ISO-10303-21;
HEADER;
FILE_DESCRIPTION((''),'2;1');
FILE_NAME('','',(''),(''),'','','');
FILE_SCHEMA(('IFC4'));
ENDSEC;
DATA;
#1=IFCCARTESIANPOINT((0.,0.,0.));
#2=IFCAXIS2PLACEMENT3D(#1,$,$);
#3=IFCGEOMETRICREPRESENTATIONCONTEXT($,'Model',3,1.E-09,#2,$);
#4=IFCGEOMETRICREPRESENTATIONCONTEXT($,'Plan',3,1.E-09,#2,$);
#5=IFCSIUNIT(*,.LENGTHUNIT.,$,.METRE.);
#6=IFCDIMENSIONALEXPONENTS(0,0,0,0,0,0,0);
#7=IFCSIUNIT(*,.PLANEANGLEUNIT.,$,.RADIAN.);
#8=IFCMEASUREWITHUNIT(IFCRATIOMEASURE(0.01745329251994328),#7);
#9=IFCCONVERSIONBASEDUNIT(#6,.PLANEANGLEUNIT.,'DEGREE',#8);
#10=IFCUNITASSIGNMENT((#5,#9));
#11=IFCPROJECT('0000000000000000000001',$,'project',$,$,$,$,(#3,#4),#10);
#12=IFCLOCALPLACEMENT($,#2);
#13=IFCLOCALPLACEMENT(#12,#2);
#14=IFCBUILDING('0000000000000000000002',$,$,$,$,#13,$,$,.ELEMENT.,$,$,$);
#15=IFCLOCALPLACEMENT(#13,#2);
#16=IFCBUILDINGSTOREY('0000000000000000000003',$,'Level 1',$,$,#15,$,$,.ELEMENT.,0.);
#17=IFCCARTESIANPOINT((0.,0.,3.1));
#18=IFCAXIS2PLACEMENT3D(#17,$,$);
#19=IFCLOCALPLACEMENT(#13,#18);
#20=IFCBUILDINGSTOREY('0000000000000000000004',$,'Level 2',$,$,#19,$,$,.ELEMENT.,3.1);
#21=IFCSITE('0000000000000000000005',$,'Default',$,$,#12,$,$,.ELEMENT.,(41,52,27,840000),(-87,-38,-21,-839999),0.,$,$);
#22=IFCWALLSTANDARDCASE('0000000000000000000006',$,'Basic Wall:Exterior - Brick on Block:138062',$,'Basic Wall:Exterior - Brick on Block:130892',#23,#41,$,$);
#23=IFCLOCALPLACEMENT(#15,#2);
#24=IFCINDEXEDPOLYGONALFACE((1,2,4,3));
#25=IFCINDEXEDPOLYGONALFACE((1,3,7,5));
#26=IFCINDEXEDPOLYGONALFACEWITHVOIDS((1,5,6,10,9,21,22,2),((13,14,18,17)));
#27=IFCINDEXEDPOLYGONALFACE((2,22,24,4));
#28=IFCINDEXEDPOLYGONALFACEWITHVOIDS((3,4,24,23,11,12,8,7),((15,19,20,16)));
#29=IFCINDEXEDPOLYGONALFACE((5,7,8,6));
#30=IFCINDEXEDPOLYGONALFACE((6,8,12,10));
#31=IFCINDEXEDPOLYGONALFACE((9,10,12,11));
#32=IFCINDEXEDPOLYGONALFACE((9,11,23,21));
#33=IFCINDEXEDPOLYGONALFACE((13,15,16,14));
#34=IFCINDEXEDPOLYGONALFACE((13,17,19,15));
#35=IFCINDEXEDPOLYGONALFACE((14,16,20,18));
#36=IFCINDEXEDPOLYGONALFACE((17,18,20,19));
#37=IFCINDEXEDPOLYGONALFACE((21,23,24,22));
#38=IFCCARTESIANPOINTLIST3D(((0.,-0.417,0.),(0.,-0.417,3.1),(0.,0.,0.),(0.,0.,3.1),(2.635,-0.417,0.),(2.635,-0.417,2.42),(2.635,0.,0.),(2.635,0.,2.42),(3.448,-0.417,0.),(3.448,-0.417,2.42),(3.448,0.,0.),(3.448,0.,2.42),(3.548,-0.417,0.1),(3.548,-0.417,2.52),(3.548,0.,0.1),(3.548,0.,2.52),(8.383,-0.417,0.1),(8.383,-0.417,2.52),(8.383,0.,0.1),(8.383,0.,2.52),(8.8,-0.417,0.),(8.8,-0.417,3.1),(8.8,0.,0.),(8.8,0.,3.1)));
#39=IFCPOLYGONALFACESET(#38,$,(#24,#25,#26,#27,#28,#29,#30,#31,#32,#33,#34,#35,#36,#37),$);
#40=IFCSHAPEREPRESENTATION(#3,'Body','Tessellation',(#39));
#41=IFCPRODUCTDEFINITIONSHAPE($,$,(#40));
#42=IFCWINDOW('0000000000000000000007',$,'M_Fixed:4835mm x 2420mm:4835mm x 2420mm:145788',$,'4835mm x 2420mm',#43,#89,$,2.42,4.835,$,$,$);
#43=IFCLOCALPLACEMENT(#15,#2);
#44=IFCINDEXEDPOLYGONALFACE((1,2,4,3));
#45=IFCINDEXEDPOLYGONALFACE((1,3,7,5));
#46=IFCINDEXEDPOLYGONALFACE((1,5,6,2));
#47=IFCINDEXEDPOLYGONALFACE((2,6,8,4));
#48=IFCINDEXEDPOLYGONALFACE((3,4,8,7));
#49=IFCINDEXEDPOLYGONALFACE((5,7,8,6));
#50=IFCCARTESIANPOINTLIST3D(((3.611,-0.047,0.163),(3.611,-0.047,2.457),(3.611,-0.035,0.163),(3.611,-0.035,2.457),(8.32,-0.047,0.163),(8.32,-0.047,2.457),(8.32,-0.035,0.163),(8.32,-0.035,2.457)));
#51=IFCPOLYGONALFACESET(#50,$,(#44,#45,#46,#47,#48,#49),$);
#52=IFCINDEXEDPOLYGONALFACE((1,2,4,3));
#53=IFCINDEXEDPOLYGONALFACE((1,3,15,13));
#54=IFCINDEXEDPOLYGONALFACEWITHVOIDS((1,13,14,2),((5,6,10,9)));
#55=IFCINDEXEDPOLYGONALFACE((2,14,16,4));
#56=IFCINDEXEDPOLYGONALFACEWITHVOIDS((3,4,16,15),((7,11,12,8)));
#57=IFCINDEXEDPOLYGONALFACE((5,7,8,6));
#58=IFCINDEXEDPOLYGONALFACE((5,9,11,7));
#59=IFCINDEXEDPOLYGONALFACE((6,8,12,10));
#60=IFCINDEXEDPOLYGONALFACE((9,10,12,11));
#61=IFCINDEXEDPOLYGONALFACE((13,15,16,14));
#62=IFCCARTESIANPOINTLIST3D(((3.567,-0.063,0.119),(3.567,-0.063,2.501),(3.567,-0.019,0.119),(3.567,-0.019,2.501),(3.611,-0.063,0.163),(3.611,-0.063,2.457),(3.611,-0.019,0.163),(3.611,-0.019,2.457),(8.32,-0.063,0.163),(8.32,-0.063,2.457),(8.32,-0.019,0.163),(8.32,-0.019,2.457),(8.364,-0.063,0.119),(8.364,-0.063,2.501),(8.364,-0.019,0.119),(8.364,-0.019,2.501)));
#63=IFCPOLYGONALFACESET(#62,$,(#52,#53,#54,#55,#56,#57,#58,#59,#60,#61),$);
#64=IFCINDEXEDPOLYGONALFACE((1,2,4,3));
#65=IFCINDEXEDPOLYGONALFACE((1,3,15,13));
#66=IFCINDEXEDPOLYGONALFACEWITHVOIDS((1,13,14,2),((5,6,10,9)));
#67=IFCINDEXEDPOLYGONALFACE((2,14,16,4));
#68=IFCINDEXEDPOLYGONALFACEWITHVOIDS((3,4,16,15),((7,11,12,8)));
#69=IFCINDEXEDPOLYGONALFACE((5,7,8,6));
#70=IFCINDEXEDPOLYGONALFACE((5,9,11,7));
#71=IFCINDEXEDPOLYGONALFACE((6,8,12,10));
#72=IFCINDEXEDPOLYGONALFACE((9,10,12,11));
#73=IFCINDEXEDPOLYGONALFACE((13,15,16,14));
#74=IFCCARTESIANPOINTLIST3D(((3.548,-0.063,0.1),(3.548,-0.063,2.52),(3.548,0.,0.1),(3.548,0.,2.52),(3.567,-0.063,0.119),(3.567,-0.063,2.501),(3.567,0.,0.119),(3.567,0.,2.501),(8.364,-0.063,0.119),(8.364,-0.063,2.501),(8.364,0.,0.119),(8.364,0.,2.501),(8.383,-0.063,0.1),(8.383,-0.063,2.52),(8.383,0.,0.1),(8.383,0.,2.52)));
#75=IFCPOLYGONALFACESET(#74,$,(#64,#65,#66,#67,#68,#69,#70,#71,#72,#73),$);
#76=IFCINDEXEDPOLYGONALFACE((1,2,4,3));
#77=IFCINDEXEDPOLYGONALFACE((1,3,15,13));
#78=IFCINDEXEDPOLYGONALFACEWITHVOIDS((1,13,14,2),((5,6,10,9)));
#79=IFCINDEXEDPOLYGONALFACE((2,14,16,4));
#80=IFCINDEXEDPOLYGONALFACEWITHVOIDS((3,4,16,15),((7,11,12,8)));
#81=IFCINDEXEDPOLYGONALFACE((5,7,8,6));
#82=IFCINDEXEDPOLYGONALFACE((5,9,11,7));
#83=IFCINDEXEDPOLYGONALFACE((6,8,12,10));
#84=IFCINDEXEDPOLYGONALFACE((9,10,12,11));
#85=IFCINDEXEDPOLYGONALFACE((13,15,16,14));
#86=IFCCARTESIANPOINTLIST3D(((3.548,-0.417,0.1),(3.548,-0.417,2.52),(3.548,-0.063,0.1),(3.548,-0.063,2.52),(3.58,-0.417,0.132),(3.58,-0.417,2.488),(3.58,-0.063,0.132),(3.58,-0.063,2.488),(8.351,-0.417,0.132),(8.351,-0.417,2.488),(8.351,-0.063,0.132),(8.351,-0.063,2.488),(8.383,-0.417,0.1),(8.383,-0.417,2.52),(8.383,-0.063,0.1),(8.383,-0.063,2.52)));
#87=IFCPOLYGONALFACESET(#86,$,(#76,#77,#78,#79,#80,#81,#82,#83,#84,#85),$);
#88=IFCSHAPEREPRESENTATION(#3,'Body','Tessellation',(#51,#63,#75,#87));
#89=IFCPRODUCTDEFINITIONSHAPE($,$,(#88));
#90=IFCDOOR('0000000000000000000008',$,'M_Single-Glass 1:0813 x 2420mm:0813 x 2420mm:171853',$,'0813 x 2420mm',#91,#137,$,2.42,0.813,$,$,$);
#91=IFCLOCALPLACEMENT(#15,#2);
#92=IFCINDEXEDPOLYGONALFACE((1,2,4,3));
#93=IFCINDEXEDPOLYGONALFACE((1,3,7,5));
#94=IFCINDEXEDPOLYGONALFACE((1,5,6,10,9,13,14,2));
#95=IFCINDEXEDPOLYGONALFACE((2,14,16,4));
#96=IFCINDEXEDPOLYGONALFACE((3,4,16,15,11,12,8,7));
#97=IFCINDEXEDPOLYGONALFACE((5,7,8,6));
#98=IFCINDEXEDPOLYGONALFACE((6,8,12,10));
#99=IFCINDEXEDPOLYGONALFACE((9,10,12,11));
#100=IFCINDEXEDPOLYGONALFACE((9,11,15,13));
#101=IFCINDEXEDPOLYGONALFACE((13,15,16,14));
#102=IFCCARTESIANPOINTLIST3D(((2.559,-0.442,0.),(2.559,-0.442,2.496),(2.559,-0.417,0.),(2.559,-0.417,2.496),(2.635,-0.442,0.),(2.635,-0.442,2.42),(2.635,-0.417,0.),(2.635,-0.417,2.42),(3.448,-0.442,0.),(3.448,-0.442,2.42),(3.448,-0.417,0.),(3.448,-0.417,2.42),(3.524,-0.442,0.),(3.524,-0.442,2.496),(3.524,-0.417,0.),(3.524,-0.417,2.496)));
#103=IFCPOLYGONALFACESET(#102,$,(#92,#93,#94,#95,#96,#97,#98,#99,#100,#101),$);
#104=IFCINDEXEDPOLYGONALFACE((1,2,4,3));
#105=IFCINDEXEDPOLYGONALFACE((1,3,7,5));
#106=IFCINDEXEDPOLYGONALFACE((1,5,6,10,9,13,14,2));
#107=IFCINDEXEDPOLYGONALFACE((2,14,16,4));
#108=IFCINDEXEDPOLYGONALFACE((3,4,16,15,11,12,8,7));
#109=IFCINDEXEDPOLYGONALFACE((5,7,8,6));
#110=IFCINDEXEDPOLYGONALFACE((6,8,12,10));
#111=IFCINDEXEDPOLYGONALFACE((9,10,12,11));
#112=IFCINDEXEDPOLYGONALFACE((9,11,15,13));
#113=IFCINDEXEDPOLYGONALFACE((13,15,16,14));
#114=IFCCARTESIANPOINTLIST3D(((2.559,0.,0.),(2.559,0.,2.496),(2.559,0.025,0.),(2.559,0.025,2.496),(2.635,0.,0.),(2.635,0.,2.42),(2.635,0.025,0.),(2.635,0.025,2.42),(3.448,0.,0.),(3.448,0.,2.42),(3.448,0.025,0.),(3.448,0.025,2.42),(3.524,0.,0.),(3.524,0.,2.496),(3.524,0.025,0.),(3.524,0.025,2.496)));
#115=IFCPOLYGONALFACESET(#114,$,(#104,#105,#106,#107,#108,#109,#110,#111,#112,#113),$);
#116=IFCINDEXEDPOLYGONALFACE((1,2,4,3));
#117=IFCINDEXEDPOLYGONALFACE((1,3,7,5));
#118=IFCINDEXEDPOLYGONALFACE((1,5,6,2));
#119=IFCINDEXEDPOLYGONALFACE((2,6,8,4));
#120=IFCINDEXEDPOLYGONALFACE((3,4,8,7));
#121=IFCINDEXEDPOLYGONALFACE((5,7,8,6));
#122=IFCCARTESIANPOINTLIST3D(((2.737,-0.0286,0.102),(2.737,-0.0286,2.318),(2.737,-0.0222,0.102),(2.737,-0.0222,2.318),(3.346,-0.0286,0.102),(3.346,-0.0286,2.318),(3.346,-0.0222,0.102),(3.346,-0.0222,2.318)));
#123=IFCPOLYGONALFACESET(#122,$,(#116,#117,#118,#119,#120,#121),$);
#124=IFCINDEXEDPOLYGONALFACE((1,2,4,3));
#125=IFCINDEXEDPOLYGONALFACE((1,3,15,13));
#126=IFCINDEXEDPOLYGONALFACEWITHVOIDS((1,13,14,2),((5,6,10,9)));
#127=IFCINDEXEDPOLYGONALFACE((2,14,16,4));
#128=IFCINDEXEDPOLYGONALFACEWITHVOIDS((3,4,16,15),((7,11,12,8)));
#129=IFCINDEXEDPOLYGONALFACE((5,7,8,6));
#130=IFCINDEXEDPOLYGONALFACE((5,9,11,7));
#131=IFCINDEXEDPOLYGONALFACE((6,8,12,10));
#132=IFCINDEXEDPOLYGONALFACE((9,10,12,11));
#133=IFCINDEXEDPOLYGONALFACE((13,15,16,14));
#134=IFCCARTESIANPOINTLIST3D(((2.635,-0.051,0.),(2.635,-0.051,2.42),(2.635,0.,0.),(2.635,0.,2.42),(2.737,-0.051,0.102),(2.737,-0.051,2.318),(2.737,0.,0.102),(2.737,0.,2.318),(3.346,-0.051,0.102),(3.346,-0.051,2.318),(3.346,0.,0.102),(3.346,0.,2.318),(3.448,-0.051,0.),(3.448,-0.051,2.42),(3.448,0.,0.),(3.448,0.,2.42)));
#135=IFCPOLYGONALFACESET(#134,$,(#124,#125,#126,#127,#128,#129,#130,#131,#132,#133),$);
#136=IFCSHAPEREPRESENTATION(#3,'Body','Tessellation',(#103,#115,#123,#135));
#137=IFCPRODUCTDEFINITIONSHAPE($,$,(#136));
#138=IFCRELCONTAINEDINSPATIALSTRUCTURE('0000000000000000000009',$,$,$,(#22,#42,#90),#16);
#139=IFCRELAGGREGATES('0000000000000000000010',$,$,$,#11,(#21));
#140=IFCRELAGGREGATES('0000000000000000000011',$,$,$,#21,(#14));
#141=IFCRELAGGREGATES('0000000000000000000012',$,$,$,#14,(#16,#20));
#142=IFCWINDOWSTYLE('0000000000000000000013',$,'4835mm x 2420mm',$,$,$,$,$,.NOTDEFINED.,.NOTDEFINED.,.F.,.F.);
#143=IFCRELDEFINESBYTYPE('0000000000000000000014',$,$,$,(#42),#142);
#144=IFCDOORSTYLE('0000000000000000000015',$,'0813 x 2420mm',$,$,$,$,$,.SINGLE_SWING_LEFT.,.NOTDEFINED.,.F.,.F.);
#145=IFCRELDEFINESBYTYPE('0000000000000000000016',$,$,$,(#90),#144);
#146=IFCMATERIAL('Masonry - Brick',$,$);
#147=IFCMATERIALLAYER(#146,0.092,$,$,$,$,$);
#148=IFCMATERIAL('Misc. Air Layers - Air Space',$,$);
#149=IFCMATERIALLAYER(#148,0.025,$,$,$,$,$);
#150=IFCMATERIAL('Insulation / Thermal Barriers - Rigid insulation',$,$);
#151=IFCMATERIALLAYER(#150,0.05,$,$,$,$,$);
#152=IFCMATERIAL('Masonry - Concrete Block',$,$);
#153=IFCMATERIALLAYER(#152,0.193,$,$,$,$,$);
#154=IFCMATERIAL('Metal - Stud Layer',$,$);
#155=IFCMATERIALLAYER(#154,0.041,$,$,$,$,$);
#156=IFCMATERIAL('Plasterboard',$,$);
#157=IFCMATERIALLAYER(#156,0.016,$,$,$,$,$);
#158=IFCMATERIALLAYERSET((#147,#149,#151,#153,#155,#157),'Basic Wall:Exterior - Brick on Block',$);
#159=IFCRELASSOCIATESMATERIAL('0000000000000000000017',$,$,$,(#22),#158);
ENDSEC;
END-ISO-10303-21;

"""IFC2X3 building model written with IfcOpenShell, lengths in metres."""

from ifc_helpers import new_model, entity, si_unit, converted_unit, frame, frame_2d, origin, origin_2d_with_axis, place, context, project, spatial, polyline, rectangle, outline, extrude, source, transform, mapped, material, layer, layer_set, layer_usage, type_object, type_shapes, element, fill, save


model = new_model("IFC2X3")

# Units and contexts
model_context_1 = context("Model", 3, precision=1e-09, world=origin())
plan_context = context("Plan", 3, precision=1e-09, world=origin())
ifc_project = project(units=[si_unit("LENGTHUNIT", "METRE"), converted_unit("PLANEANGLEUNIT", "DEGREE", entity("IfcRatioMeasure", 0.01745329251994328), si_unit("PLANEANGLEUNIT", "RADIAN"), dimensions=[0, 0, 0, 0, 0, 0, 0])], contexts=[model_context_1, plan_context])

# Site, building, storey
site_placement = place(None, origin())
site = spatial("IfcSite", under=ifc_project, at=site_placement, Name="Default", CompositionType="ELEMENT", RefLatitude=(41, 52, 27, 840000), RefLongitude=(-87, -38, -21, -839999), RefElevation=0.0)
building_placement = place(site_placement, origin())
building = spatial("IfcBuilding", under=site, at=building_placement, CompositionType="ELEMENT")
storey_1_placement = place(building_placement, origin())
storey_1 = spatial("IfcBuildingStorey", under=building, at=storey_1_placement, Name="Level 1", CompositionType="ELEMENT", Elevation=0.0)

# Wall, openings, window, door
ifc_material_1 = material(Name="Masonry - Brick")
ifc_layer_1 = layer(ifc_material_1, 0.092)
ifc_material_2 = material(Name="Misc. Air Layers - Air Space")
ifc_layer_2 = layer(ifc_material_2, 0.025)
ifc_material_3 = material(Name="Insulation / Thermal Barriers - Rigid insulation")
ifc_layer_3 = layer(ifc_material_3, 0.05)
ifc_material_4 = material(Name="Masonry - Concrete Block")
ifc_layer_4 = layer(ifc_material_4, 0.193)
ifc_material_5 = material(Name="Metal - Stud Layer")
ifc_layer_5 = layer(ifc_material_5, 0.041)
ifc_material_6 = material(Name="Plasterboard")
ifc_layer_6 = layer(ifc_material_6, 0.016)
ifc_layer_set_1 = layer_set([ifc_layer_1, ifc_layer_2, ifc_layer_3, ifc_layer_4, ifc_layer_5, ifc_layer_6], Name="Basic Wall:Exterior - Brick on Block")
ifc_layer_usage_1 = layer_usage(ifc_layer_set_1, "AXIS2", "NEGATIVE", 0.2085)
wall_1_placement = place(storey_1_placement, frame((0.0, -0.2085, 0.0)))
wall_1 = element("IfcWallStandardCase", 1, at=wall_1_placement, inside=storey_1, material=ifc_layer_usage_1, Name="Basic Wall:Exterior - Brick on Block:138062", ObjectType="Basic Wall:Exterior - Brick on Block:130892", context=model_context_1, shape_type="SweptSolid", body=[
    extrude(rectangle(XDim=8.8, YDim=0.417, at=frame_2d((4.4, 0.0), x_axis=(-1.0, 0.0))), origin(), (0.0, 0.0, 1.0), 3.1),
])
opening_1_placement = place(wall_1_placement, frame((3.548, -0.2085, 0.1)))
opening_1 = element("IfcOpeningElement", 2, at=opening_1_placement, cuts=wall_1, ObjectType="Opening", context=model_context_1, shape_type="SweptSolid", body=[
    extrude(rectangle(XDim=2.42, YDim=4.835, at=frame_2d((1.21, 2.4175), x_axis=(1.0, 0.0))), frame((0.0, 0.0, 0.0), z_axis=(0.0, 1.0, 0.0), x_axis=(0.0, 0.0, 1.0)), (0.0, 0.0, 1.0), 0.417),
])
opening_2_placement = place(wall_1_placement, frame((2.635, -0.2085, 0.0)))
opening_2 = element("IfcOpeningElement", 3, at=opening_2_placement, cuts=wall_1, ObjectType="Opening", context=model_context_1, shape_type="SweptSolid", body=[
    extrude(rectangle(XDim=0.813, YDim=2.42, at=frame_2d((1.21, 0.4065), x_axis=(0.0, -1.0))), frame((0.0, 0.0, 0.0), z_axis=(0.0, 1.0, 0.0), x_axis=(0.0, 0.0, 1.0)), (0.0, 0.0, 1.0), 0.417),
])
window_style_1 = type_object("IfcWindowStyle", Name="4835mm x 2420mm", ConstructionType="NOTDEFINED", OperationType="NOTDEFINED", ParameterTakesPrecedence=False, Sizeable=False)
shared_shape_1 = source(origin(), model_context_1, "Body", "SweptSolid", [
    extrude(rectangle(XDim=0.012, YDim=4.709, at=origin_2d_with_axis()), frame((2.4175, 0.376, 0.063), z_axis=(0.0, 0.0, 1.0), x_axis=(0.0, -1.0, 0.0)), (0.0, 0.0, 1.0), 2.294),
    extrude(outline(polyline([(-2.3985, -1.191), (2.3985, -1.191), (2.3985, 1.191), (-2.3985, 1.191), (-2.3985, -1.191)]), holes=[polyline([(-2.3545, -1.147), (-2.3545, 1.147), (2.3545, 1.147), (2.3545, -1.147), (-2.3545, -1.147)])]), frame((2.4175, 0.354, 1.21), z_axis=(0.0, 1.0, 0.0), x_axis=(1.0, 0.0, 0.0)), (0.0, 0.0, 1.0), 0.044),
    extrude(outline(polyline([(-2.4175, -1.21), (2.4175, -1.21), (2.4175, 1.21), (-2.4175, 1.21), (-2.4175, -1.21)]), holes=[polyline([(-2.3985, -1.191), (-2.3985, 1.191), (2.3985, 1.191), (2.3985, -1.191), (-2.3985, -1.191)])]), frame((2.4175, 0.354, 1.21), z_axis=(0.0, 1.0, 0.0), x_axis=(1.0, 0.0, 0.0)), (0.0, 0.0, 1.0), 0.063),
    extrude(outline(polyline([(-2.4175, -1.21), (2.4175, -1.21), (2.4175, 1.21), (-2.4175, 1.21), (-2.4175, -1.21)]), holes=[polyline([(-2.3855, -1.178), (-2.3855, 1.178), (2.3855, 1.178), (2.3855, -1.178), (-2.3855, -1.178)])]), frame((2.4175, 0.0, 1.21), z_axis=(0.0, 1.0, 0.0), x_axis=(1.0, 0.0, 0.0)), (0.0, 0.0, 1.0), 0.354),
])
type_shapes(window_style_1, [shared_shape_1])
window_1_placement = place(opening_1_placement, origin())
window_1 = element("IfcWindow", 4, at=window_1_placement, inside=storey_1, type_object=window_style_1, Name="M_Fixed:4835mm x 2420mm:4835mm x 2420mm:145788", ObjectType="4835mm x 2420mm", OverallHeight=2.42, OverallWidth=4.835, context=model_context_1, shape_type="MappedRepresentation", body=[
    mapped(shared_shape_1, transform((0.0, 0.0, 0.0), scale=1.0)),
])
fill(opening_1, window_1)
door_style_1 = type_object("IfcDoorStyle", Name="0813 x 2420mm", ConstructionType="NOTDEFINED", OperationType="SINGLE_SWING_LEFT", ParameterTakesPrecedence=False, Sizeable=False)
shared_shape_2 = source(origin(), model_context_1, "Body", "SweptSolid", [
    extrude(outline(polyline([(-0.4065, -1.191), (-0.4065, 1.229), (-0.4825, 1.229), (-0.4825, -1.267), (0.4825, -1.267), (0.4825, 1.229), (0.4065, 1.229), (0.4065, -1.191), (-0.4065, -1.191)])), frame((0.4065, 0.0, 1.229), z_axis=(0.0, 1.0, 0.0), x_axis=(1.0, 0.0, 0.0)), (0.0, 0.0, -1.0), 0.025),
    extrude(outline(polyline([(-0.4065, -1.191), (-0.4065, 1.229), (-0.4825, 1.229), (-0.4825, -1.267), (0.4825, -1.267), (0.4825, 1.229), (0.4065, 1.229), (0.4065, -1.191), (-0.4065, -1.191)])), frame((0.4065, 0.442, 1.229), z_axis=(0.0, 1.0, 0.0), x_axis=(1.0, 0.0, 0.0)), (0.0, 0.0, -1.0), 0.025),
    extrude(rectangle(XDim=0.609, YDim=0.0064, at=origin_2d_with_axis()), frame((0.4065, 0.3916, 0.102)), (0.0, 0.0, 1.0), 2.216),
    extrude(outline(polyline([(-1.21, -0.4065), (1.21, -0.4065), (1.21, 0.4065), (-1.21, 0.4065), (-1.21, -0.4065)]), holes=[polyline([(-1.108, 0.3045), (1.108, 0.3045), (1.108, -0.3045), (-1.108, -0.3045), (-1.108, 0.3045)])]), frame((0.4065, 0.417, 1.21), z_axis=(0.0, -1.0, 0.0), x_axis=(0.0, 0.0, -1.0)), (0.0, 0.0, 1.0), 0.051),
])
type_shapes(door_style_1, [shared_shape_2])
door_1_placement = place(opening_2_placement, origin())
door_1 = element("IfcDoor", 5, at=door_1_placement, inside=storey_1, type_object=door_style_1, Name="M_Single-Glass 1:0813 x 2420mm:0813 x 2420mm:171853", ObjectType="0813 x 2420mm", OverallHeight=2.42, OverallWidth=0.813, context=model_context_1, shape_type="MappedRepresentation", body=[
    mapped(shared_shape_2, transform((0.0, 0.0, 0.0), scale=1.0)),
])
fill(opening_2, door_1)

# Shared definitions
storey_2_placement = place(building_placement, frame((0.0, 0.0, 3.1)))
storey_2 = spatial("IfcBuildingStorey", under=building, at=storey_2_placement, Name="Level 2", CompositionType="ELEMENT", Elevation=3.1)

save(model, "model.ifc")
